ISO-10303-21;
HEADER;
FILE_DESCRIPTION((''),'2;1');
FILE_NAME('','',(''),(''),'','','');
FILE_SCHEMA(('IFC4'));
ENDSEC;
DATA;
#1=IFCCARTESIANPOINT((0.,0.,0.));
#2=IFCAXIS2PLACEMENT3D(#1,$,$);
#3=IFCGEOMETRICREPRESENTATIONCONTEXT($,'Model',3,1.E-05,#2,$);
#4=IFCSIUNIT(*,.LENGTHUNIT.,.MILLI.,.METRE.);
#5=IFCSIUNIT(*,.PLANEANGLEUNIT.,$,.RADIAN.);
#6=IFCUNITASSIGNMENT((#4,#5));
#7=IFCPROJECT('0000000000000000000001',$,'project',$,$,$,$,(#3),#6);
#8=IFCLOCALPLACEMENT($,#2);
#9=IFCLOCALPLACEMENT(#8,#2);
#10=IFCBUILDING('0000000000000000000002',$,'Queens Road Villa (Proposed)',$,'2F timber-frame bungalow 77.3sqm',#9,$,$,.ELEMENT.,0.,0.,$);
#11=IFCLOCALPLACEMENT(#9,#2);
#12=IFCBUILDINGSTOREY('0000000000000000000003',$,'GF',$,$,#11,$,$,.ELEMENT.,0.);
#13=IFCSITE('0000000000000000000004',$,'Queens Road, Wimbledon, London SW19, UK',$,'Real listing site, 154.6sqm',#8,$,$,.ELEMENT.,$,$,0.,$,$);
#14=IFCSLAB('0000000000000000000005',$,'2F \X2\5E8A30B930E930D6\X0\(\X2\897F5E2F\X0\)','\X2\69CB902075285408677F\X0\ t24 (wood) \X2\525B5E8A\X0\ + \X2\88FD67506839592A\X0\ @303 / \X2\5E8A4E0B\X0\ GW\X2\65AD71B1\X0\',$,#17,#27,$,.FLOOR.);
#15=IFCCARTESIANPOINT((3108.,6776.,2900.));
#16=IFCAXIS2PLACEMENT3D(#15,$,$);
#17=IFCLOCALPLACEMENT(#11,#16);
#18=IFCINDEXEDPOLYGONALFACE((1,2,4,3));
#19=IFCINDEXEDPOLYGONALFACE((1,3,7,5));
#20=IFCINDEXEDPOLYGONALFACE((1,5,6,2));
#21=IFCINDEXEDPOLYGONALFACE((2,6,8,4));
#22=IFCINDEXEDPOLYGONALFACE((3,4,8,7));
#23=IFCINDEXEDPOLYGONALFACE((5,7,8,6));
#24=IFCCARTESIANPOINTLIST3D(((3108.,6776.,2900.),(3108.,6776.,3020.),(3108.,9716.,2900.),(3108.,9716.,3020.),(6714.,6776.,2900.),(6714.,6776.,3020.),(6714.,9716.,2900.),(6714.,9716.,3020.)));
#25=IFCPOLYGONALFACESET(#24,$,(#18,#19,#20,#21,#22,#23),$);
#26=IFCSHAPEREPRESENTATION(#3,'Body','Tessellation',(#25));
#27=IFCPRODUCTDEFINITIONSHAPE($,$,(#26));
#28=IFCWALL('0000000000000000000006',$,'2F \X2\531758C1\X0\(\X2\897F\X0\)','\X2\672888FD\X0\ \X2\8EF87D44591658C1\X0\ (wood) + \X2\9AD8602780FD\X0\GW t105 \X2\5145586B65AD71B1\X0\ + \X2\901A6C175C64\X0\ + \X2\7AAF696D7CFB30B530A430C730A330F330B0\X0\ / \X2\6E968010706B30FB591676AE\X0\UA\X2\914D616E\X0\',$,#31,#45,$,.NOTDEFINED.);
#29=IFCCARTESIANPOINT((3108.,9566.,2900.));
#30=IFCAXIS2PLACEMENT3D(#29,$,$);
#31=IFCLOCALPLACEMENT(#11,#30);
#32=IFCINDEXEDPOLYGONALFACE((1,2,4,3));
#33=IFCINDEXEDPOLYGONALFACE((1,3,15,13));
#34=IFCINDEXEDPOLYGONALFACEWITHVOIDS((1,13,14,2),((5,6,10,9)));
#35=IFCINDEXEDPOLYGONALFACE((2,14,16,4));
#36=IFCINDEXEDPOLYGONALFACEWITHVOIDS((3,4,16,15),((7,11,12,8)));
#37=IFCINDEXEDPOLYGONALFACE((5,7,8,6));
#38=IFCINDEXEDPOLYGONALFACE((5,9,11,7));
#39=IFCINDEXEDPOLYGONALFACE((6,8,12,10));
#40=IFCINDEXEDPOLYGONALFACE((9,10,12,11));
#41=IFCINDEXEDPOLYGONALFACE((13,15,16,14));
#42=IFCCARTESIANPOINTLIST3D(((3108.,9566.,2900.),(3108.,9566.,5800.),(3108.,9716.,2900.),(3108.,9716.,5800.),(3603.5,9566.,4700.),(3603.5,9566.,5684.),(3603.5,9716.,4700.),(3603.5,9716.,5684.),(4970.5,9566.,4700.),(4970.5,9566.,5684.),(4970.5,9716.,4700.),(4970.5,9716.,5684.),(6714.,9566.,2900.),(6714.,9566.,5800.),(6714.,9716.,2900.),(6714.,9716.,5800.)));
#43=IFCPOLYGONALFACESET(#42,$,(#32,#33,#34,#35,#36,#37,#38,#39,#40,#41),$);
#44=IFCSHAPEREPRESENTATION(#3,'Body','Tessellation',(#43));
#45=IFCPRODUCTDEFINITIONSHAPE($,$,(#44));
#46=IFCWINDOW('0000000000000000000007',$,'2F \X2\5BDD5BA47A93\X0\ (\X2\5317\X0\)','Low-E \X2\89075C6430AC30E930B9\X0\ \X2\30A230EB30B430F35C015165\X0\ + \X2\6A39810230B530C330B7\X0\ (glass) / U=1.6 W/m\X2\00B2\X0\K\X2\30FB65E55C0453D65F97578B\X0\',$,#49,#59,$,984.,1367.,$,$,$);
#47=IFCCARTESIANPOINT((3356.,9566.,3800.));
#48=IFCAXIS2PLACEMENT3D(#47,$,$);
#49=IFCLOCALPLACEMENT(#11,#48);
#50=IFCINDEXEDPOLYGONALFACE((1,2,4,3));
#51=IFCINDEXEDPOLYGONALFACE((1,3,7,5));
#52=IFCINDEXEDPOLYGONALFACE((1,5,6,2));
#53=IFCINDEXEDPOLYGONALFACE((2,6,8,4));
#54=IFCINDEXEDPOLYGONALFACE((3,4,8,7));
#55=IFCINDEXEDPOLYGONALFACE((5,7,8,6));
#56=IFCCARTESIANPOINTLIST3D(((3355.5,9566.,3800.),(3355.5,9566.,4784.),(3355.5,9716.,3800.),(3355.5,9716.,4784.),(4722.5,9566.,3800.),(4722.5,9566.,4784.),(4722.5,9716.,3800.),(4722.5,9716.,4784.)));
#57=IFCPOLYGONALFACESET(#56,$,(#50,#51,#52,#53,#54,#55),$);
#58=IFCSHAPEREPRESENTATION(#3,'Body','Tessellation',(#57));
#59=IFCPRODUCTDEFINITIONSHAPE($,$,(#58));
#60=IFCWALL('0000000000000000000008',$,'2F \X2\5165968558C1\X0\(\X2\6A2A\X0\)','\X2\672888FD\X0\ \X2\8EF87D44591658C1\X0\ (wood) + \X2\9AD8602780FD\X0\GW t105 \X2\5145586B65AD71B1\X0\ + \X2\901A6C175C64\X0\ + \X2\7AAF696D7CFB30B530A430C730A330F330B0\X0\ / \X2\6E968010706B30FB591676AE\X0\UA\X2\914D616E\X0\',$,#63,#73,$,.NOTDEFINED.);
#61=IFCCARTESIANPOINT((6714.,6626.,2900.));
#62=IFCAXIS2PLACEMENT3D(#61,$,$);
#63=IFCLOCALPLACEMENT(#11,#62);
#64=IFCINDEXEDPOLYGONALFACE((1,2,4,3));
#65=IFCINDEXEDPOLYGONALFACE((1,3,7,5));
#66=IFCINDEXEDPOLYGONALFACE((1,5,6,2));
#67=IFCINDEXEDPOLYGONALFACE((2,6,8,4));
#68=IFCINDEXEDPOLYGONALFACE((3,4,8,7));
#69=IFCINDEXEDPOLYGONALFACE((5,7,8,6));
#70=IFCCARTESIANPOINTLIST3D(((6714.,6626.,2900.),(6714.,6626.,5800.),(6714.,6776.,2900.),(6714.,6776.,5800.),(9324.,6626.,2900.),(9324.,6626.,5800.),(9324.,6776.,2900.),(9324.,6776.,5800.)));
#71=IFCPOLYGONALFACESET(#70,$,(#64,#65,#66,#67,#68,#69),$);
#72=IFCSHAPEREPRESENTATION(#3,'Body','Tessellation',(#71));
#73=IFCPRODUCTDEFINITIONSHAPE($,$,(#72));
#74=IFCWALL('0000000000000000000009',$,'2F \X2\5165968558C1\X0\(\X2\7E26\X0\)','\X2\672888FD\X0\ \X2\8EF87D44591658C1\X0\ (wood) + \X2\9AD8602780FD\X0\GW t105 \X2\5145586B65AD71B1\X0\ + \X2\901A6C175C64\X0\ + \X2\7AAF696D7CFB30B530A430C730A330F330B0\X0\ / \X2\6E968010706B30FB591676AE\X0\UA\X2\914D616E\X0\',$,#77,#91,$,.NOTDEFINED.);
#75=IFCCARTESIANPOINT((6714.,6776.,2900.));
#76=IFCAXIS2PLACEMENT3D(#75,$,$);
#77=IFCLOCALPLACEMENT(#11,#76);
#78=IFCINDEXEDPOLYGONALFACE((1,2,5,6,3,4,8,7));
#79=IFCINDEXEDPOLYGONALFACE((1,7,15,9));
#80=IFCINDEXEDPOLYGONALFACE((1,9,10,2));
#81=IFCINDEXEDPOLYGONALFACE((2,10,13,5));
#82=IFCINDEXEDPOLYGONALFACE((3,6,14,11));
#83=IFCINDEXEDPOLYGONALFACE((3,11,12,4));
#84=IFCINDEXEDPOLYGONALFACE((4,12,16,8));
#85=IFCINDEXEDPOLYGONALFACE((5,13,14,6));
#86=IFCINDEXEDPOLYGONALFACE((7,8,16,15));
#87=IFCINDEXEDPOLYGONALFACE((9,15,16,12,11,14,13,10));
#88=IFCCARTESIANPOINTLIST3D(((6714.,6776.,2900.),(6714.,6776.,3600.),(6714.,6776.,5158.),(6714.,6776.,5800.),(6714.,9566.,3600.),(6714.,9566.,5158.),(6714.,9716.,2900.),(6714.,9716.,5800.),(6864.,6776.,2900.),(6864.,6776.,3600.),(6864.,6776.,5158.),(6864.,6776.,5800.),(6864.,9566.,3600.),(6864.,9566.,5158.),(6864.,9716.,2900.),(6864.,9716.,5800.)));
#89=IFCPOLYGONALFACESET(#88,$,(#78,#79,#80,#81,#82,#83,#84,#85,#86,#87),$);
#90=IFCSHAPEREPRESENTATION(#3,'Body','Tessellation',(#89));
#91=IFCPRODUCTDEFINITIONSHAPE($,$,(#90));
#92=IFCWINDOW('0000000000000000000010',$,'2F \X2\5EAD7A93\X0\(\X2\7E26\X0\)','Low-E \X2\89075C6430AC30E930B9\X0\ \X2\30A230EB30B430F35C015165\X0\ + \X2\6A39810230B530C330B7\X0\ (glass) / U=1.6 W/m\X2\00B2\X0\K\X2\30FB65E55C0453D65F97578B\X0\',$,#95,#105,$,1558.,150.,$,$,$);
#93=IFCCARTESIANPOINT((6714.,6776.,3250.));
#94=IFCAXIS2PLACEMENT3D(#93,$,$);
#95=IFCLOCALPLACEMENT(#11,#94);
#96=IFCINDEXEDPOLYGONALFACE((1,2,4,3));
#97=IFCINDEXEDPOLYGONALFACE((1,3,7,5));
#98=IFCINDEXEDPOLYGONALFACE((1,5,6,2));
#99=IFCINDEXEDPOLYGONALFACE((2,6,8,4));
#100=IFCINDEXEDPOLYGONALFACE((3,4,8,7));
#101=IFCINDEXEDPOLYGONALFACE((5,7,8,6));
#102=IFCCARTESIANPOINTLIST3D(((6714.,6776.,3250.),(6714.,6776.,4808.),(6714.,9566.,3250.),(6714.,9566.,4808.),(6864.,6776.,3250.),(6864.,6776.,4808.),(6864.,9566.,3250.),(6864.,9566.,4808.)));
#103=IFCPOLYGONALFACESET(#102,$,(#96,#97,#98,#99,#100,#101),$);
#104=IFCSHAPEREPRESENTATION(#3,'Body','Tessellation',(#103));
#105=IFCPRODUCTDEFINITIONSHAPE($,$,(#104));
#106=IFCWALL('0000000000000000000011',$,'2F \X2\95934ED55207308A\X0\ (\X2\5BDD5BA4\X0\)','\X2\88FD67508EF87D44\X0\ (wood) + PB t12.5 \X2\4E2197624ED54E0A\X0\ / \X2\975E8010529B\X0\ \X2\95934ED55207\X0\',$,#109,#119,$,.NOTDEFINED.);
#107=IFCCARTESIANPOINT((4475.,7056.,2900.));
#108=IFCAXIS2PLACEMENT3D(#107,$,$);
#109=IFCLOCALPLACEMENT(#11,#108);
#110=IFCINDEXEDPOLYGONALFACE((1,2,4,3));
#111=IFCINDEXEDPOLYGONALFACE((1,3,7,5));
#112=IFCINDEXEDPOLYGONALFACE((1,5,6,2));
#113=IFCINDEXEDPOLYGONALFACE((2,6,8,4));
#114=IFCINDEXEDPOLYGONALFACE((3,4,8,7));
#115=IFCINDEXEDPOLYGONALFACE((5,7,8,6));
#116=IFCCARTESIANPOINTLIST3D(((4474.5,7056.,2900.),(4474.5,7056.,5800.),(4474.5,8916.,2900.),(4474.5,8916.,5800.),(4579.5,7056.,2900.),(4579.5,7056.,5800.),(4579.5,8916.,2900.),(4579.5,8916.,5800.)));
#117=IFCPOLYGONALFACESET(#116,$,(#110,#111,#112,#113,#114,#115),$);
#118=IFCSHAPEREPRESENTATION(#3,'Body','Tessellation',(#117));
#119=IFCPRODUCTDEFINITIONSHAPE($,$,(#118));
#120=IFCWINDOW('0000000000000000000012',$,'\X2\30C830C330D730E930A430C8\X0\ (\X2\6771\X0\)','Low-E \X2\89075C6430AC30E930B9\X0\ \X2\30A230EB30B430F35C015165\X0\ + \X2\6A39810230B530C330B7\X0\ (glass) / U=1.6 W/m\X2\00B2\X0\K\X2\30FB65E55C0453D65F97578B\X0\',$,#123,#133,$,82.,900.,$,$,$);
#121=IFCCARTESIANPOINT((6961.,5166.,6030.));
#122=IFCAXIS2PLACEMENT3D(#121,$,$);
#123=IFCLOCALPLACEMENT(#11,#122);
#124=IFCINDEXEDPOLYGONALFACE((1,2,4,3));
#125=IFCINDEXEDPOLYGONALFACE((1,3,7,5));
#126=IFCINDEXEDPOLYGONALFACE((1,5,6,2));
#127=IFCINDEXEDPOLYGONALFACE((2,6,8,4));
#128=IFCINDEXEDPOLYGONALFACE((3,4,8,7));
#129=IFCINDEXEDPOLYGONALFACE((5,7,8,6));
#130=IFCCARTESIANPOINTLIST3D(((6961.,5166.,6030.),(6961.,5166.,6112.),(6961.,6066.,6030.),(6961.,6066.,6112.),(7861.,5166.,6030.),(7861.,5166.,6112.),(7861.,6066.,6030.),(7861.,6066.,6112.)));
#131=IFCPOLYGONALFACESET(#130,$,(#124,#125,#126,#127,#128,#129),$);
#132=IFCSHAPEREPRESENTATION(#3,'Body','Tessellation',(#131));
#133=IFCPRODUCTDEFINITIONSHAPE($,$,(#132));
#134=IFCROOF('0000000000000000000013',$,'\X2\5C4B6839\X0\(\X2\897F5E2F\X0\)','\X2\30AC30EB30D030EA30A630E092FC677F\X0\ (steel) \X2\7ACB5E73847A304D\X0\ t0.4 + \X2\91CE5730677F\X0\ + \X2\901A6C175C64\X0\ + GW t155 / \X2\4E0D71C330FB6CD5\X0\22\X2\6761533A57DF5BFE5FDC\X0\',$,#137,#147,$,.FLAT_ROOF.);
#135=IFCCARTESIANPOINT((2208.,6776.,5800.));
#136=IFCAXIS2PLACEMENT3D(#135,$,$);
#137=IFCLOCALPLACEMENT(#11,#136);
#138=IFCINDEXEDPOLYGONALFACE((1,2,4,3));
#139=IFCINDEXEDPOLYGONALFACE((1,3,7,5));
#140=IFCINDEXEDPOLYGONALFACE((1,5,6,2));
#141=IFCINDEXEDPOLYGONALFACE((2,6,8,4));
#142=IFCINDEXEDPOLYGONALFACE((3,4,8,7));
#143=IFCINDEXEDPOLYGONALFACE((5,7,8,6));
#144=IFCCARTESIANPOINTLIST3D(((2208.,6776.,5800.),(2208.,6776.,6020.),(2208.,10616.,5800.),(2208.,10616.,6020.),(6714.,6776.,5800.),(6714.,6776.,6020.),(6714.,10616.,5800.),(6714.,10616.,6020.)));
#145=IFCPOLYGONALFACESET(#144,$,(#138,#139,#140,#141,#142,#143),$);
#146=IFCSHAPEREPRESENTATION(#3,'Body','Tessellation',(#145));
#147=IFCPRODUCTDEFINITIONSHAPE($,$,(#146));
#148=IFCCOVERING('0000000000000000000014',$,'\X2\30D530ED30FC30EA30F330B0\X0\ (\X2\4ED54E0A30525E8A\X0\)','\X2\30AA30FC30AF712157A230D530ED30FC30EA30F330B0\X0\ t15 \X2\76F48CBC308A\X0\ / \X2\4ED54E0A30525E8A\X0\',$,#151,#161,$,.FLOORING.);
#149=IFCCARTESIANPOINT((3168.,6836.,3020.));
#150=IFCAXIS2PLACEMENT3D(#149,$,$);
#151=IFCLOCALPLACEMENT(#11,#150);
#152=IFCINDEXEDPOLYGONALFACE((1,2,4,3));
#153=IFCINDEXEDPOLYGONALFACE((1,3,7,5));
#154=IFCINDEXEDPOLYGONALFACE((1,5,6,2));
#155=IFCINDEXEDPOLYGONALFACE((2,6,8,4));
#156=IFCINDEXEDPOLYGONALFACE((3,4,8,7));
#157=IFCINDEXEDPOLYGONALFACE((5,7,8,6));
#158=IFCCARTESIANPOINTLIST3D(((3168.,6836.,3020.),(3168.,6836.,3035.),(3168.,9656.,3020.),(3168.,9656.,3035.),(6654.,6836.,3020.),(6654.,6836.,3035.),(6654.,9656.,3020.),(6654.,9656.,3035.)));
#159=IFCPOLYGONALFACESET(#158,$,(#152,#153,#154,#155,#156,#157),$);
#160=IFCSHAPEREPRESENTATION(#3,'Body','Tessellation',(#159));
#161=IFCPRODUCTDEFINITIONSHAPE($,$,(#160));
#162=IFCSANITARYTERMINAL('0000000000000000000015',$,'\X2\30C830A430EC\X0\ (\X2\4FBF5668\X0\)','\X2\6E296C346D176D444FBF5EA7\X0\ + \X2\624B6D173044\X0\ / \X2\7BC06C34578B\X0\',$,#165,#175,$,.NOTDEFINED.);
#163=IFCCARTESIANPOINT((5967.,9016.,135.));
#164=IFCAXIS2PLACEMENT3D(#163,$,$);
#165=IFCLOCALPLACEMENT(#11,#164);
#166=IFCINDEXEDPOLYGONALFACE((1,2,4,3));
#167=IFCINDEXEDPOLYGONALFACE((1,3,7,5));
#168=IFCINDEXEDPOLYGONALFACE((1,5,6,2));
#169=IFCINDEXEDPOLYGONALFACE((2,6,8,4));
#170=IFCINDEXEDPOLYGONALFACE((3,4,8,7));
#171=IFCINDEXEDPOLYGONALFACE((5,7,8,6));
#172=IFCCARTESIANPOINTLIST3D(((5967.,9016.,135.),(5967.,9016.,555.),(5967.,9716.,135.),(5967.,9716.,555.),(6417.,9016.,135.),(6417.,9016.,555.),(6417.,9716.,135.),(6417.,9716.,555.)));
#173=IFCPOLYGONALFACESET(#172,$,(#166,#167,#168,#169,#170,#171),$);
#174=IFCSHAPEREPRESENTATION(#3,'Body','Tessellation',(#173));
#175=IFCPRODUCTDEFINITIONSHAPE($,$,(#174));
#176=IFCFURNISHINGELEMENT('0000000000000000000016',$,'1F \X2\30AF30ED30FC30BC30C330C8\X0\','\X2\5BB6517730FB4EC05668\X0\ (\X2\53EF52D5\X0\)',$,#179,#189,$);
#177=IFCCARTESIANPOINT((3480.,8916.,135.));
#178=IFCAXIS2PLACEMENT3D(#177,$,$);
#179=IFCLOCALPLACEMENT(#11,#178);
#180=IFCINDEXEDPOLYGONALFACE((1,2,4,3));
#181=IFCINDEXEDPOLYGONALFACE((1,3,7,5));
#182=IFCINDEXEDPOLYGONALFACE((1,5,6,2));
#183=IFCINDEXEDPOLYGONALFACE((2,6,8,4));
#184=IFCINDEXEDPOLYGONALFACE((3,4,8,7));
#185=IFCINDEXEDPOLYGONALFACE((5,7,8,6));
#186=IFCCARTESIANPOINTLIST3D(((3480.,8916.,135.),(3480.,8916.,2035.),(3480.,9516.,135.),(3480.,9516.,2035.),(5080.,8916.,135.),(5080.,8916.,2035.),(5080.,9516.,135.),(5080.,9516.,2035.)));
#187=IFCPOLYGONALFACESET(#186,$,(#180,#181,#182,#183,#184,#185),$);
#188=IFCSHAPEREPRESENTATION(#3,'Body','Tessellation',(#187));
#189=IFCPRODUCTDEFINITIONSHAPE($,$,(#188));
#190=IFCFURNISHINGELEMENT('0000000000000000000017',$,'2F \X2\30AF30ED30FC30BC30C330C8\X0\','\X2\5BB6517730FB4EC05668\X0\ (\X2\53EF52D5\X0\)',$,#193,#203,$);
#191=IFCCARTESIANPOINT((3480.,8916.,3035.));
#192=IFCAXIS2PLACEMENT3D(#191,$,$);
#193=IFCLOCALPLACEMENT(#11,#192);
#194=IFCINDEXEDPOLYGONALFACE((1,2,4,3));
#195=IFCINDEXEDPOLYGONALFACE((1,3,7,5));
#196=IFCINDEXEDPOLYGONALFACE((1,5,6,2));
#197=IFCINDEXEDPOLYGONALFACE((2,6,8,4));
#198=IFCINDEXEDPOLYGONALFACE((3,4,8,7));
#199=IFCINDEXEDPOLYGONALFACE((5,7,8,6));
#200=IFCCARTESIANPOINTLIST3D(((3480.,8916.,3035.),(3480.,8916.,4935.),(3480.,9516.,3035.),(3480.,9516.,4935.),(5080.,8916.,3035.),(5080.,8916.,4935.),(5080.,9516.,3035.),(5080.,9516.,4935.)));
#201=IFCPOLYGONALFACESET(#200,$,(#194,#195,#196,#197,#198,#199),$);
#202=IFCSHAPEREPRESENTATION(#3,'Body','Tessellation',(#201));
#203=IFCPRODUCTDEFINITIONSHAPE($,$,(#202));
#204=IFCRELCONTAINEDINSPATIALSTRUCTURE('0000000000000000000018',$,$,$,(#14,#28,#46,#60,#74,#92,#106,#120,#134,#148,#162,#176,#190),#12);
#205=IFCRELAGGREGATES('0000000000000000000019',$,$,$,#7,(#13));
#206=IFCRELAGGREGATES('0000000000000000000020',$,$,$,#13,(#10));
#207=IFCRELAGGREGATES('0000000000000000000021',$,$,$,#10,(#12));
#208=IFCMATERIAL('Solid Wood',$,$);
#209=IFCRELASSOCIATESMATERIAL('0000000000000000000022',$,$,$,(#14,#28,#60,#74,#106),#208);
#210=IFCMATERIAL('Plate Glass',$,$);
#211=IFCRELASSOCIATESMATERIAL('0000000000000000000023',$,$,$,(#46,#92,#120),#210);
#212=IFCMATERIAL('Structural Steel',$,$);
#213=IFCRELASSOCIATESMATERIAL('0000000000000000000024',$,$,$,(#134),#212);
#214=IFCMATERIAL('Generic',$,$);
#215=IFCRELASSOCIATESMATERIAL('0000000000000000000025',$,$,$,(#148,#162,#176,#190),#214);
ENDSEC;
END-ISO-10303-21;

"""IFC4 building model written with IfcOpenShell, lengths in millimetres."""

from ifc_helpers import new_model, si_unit, frame, frame_2d, origin, place, context, project, spatial, rectangle, extrude, material, element, fill, save


model = new_model("IFC4")

# Units and contexts
model_context = context("Model", 3, precision=1e-05, world=origin())
ifc_project = project(units=[si_unit("LENGTHUNIT", "METRE", prefix="MILLI"), si_unit("PLANEANGLEUNIT", "RADIAN")], contexts=[model_context])

# Site, building, storey
site_placement = place(None, origin())
site = spatial("IfcSite", under=ifc_project, at=site_placement, Name="Queens Road, Wimbledon, London SW19, UK", ObjectType="Real listing site, 154.6sqm", CompositionType="ELEMENT", RefElevation=0.0)
building_placement = place(site_placement, origin())
building = spatial("IfcBuilding", under=site, at=building_placement, Name="Queens Road Villa (Proposed)", ObjectType="2F timber-frame bungalow 77.3sqm", CompositionType="ELEMENT", ElevationOfRefHeight=0.0, ElevationOfTerrain=0.0)
storey_placement = place(building_placement, origin())
storey = spatial("IfcBuildingStorey", under=building, at=storey_placement, Name="GF", CompositionType="ELEMENT", Elevation=0.0)

# Slab
ifc_material_1 = material(Name="Solid Wood")
slab_placement = place(storey_placement, frame((3108.0, 6776.0, 2900.0)))
element("IfcSlab", 1, at=slab_placement, inside=storey, material=ifc_material_1, Name="2F 床スラブ(西帯)", Description="構造用合板 t24 (wood) 剛床 + 製材根太 @303 / 床下 GW断熱", PredefinedType="FLOOR", context=model_context, shape_type="SweptSolid", body=[
    extrude(rectangle(XDim=3606.0, YDim=2940.0, at=frame_2d((1803.0, 1470.0))), frame((3108.0, 6776.0, 2900.0)), (0.0, 0.0, 1.0), 120.0),
])

# Wall, opening, window
wall_1_placement = place(storey_placement, frame((3108.0, 9566.0, 2900.0)))
wall_1 = element("IfcWall", 2, at=wall_1_placement, inside=storey, material=ifc_material_1, Name="2F 北壁(西)", Description="木製 軸組外壁 (wood) + 高性能GW t105 充填断熱 + 通気層 + 窯業系サイディング / 準耐火・外皮UA配慮", PredefinedType="NOTDEFINED", context=model_context, shape_type="SweptSolid", body=[
    extrude(rectangle(XDim=3606.0, YDim=150.0, at=frame_2d((1803.0, 75.0))), frame((3108.0, 9566.0, 2900.0)), (0.0, 0.0, 1.0), 2900.0),
])
opening_1_placement = place(storey_placement, frame((3356.0, 9566.0, 3800.0)))
opening_1 = element("IfcOpeningElement", 3, at=opening_1_placement, cuts=wall_1, PredefinedType="NOTDEFINED", context=model_context, shape_type="SweptSolid", body=[
    extrude(rectangle(XDim=1367.0, YDim=150.0, at=frame_2d((683.0, 75.0))), frame((3356.0, 9566.0, 3800.0)), (0.0, 0.0, 1.0), 984.0),
])
ifc_material_2 = material(Name="Plate Glass")
window_1_placement = place(storey_placement, frame((3356.0, 9566.0, 3800.0)))
window_1 = element("IfcWindow", 4, at=window_1_placement, inside=storey, material=ifc_material_2, Name="2F 寝室窓 (北)", Description="Low-E 複層ガラス アルゴン封入 + 樹脂サッシ (glass) / U=1.6 W/m²K・日射取得型", OverallHeight=984.0, OverallWidth=1367.0, context=model_context, shape_type="SweptSolid", body=[
    extrude(rectangle(XDim=1367.0, YDim=150.0, at=frame_2d((683.0, 75.0))), frame((3356.0, 9566.0, 3800.0)), (0.0, 0.0, 1.0), 984.0),
])
fill(opening_1, window_1)

# Wall
wall_2_placement = place(storey_placement, frame((6714.0, 6626.0, 2900.0)))
element("IfcWall", 5, at=wall_2_placement, inside=storey, material=ifc_material_1, Name="2F 入隅壁(横)", Description="木製 軸組外壁 (wood) + 高性能GW t105 充填断熱 + 通気層 + 窯業系サイディング / 準耐火・外皮UA配慮", PredefinedType="NOTDEFINED", context=model_context, shape_type="SweptSolid", body=[
    extrude(rectangle(XDim=2610.0, YDim=150.0, at=frame_2d((1305.0, 75.0))), frame((6714.0, 6626.0, 2900.0)), (0.0, 0.0, 1.0), 2900.0),
])

# Wall, opening, window
wall_3_placement = place(storey_placement, frame((6714.0, 6776.0, 2900.0)))
wall_3 = element("IfcWall", 6, at=wall_3_placement, inside=storey, material=ifc_material_1, Name="2F 入隅壁(縦)", Description="木製 軸組外壁 (wood) + 高性能GW t105 充填断熱 + 通気層 + 窯業系サイディング / 準耐火・外皮UA配慮", PredefinedType="NOTDEFINED", context=model_context, shape_type="SweptSolid", body=[
    extrude(rectangle(XDim=150.0, YDim=2940.0, at=frame_2d((75.0, 1470.0))), frame((6714.0, 6776.0, 2900.0)), (0.0, 0.0, 1.0), 2900.0),
])
opening_2_placement = place(storey_placement, frame((6714.0, 6776.0, 3250.0)))
opening_2 = element("IfcOpeningElement", 7, at=opening_2_placement, cuts=wall_3, PredefinedType="NOTDEFINED", context=model_context, shape_type="SweptSolid", body=[
    extrude(rectangle(XDim=150.0, YDim=2790.0, at=frame_2d((75.0, 1395.0))), frame((6714.0, 6776.0, 3250.0)), (0.0, 0.0, 1.0), 1558.0),
])
window_2_placement = place(storey_placement, frame((6714.0, 6776.0, 3250.0)))
window_2 = element("IfcWindow", 8, at=window_2_placement, inside=storey, material=ifc_material_2, Name="2F 庭窓(縦)", Description="Low-E 複層ガラス アルゴン封入 + 樹脂サッシ (glass) / U=1.6 W/m²K・日射取得型", OverallHeight=1558.0, OverallWidth=150.0, context=model_context, shape_type="SweptSolid", body=[
    extrude(rectangle(XDim=150.0, YDim=2790.0, at=frame_2d((75.0, 1395.0))), frame((6714.0, 6776.0, 3250.0)), (0.0, 0.0, 1.0), 1558.0),
])
fill(opening_2, window_2)

# Wall
wall_4_placement = place(storey_placement, frame((4475.0, 7056.0, 2900.0)))
element("IfcWall", 9, at=wall_4_placement, inside=storey, material=ifc_material_1, Name="2F 間仕切り (寝室)", Description="製材軸組 (wood) + PB t12.5 両面仕上 / 非耐力 間仕切", PredefinedType="NOTDEFINED", context=model_context, shape_type="SweptSolid", body=[
    extrude(rectangle(XDim=105.0, YDim=1860.0, at=frame_2d((52.0, 930.0))), frame((4475.0, 7056.0, 2900.0)), (0.0, 0.0, 1.0), 2900.0),
])

# Window
window_3_placement = place(storey_placement, frame((6961.0, 5166.0, 6030.0)))
element("IfcWindow", 10, at=window_3_placement, inside=storey, material=ifc_material_2, Name="トップライト (東)", Description="Low-E 複層ガラス アルゴン封入 + 樹脂サッシ (glass) / U=1.6 W/m²K・日射取得型", OverallHeight=82.0, OverallWidth=900.0, context=model_context, shape_type="SweptSolid", body=[
    extrude(rectangle(XDim=900.0, YDim=900.0, at=frame_2d((450.0, 450.0))), frame((6961.0, 5166.0, 6030.0)), (0.0, 0.0, 1.0), 82.0),
])

# Roof
ifc_material_3 = material(Name="Structural Steel")
for number, where, name in (
    (11, (2208.0, 6776.0, 5800.0), "屋根(西帯)"),
):
    element("IfcRoof", number, at=place(storey_placement, frame(where)), inside=storey, material=ifc_material_3, Name=name, Description="ガルバリウム鋼板 (steel) 立平葺き t0.4 + 野地板 + 通気層 + GW t155 / 不燃・法22条区域対応", PredefinedType="FLAT_ROOF", context=model_context, shape_type="SweptSolid", body=[
        extrude(rectangle(XDim=4506.0, YDim=3840.0, at=frame_2d((2253.0, 1920.0))), frame((2208.0, 6776.0, 5800.0)), (0.0, 0.0, 1.0), 220.0),
    ])

# Covering
ifc_material_4 = material(Name="Generic")
covering_placement = place(storey_placement, frame((3168.0, 6836.0, 3020.0)))
element("IfcCovering", 12, at=covering_placement, inside=storey, material=ifc_material_4, Name="フローリング (仕上げ床)", Description="オーク無垢フローリング t15 直貼り / 仕上げ床", PredefinedType="FLOORING", context=model_context, shape_type="SweptSolid", body=[
    extrude(rectangle(XDim=3486.0, YDim=2820.0, at=frame_2d((1743.0, 1410.0))), frame((3168.0, 6836.0, 3020.0)), (0.0, 0.0, 1.0), 15.0),
])

# Sanitary terminal
sanitary_terminal_placement = place(storey_placement, frame((5967.0, 9016.0, 135.0)))
element("IfcSanitaryTerminal", 13, at=sanitary_terminal_placement, inside=storey, material=ifc_material_4, Name="トイレ (便器)", Description="温水洗浄便座 + 手洗い / 節水型", PredefinedType="NOTDEFINED", context=model_context, shape_type="SweptSolid", body=[
    extrude(rectangle(XDim=450.0, YDim=700.0, at=frame_2d((225.0, 350.0))), frame((5967.0, 9016.0, 135.0)), (0.0, 0.0, 1.0), 420.0),
])

# Furnishing elements
furnishing_1_placement = place(storey_placement, frame((3480.0, 8916.0, 135.0)))
element("IfcFurnishingElement", 14, at=furnishing_1_placement, inside=storey, material=ifc_material_4, Name="1F クローゼット", Description="家具・什器 (可動)", context=model_context, shape_type="SweptSolid", body=[
    extrude(rectangle(XDim=1600.0, YDim=600.0, at=frame_2d((800.0, 300.0))), frame((3480.0, 8916.0, 135.0)), (0.0, 0.0, 1.0), 1900.0),
])
furnishing_2_placement = place(storey_placement, frame((3480.0, 8916.0, 3035.0)))
element("IfcFurnishingElement", 15, at=furnishing_2_placement, inside=storey, material=ifc_material_4, Name="2F クローゼット", Description="家具・什器 (可動)", context=model_context, shape_type="SweptSolid", body=[
    extrude(rectangle(XDim=1600.0, YDim=600.0, at=frame_2d((800.0, 300.0))), frame((3480.0, 8916.0, 3035.0)), (0.0, 0.0, 1.0), 1900.0),
])

save(model, "model.ifc")
